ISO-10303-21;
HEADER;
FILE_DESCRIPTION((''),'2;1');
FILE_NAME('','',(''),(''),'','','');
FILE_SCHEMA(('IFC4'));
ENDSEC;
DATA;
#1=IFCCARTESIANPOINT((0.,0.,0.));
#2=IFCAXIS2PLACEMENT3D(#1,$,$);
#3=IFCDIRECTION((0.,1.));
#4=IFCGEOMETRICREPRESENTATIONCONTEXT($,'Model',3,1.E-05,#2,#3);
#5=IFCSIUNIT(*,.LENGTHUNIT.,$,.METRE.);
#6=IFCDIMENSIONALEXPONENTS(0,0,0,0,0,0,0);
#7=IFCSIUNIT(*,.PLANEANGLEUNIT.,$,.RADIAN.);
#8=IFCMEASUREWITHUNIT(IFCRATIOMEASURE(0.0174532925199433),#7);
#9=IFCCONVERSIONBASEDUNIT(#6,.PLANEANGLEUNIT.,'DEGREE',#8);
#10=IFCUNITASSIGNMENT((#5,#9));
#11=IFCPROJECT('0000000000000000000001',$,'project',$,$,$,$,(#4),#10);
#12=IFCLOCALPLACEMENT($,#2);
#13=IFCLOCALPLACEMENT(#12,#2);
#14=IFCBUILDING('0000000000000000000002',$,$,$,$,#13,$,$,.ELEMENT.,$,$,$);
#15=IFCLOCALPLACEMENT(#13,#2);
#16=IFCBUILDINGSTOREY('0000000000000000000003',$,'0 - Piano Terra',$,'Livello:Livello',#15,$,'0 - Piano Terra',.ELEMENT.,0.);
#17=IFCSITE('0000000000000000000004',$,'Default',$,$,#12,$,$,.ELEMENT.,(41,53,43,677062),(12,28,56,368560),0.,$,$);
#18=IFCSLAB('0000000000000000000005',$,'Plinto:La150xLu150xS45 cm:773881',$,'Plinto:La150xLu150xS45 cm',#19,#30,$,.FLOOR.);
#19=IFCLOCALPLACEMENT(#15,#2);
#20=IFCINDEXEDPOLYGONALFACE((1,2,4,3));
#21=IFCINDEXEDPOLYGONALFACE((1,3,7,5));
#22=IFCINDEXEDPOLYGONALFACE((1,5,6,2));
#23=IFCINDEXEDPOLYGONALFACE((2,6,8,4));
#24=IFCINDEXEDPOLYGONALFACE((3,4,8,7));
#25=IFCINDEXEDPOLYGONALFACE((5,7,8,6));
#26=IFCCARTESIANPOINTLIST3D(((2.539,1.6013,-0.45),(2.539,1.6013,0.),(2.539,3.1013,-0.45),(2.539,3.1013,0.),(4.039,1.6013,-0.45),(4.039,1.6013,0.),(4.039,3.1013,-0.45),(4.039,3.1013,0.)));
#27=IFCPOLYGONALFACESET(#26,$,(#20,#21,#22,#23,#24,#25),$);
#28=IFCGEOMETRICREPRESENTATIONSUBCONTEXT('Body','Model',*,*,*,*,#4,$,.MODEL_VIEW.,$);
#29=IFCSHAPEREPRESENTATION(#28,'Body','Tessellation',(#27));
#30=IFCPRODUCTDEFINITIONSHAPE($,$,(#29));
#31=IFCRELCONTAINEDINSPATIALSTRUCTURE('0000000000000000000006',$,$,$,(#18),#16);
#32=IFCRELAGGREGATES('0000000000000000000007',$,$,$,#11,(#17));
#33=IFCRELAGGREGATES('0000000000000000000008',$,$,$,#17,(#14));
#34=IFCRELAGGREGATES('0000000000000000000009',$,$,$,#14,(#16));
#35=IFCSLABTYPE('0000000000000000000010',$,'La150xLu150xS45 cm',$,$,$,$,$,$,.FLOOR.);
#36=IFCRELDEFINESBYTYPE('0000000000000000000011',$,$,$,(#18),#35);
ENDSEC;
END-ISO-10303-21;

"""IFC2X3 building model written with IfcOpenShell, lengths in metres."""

from ifc_helpers import new_model, entity, si_unit, converted_unit, direction, frame, frame_2d, origin, place, context, subcontext, project, spatial, rectangle, extrude, type_object, element, save


model = new_model("IFC2X3")

# Units and contexts
model_context = context("Model", 3, precision=1e-05, world=origin(), true_north=direction((0.0, 1.0)))
body_context = subcontext(model_context, "Body", "Model", "MODEL_VIEW")
ifc_project = project(units=[si_unit("LENGTHUNIT", "METRE"), converted_unit("PLANEANGLEUNIT", "DEGREE", entity("IfcRatioMeasure", 0.0174532925199433), si_unit("PLANEANGLEUNIT", "RADIAN"), dimensions=[0, 0, 0, 0, 0, 0, 0])], contexts=[model_context])

# Site, building, storey
site_placement = place(None, origin())
site = spatial("IfcSite", under=ifc_project, at=site_placement, Name="Default", CompositionType="ELEMENT", RefLatitude=(41, 53, 43, 677062), RefLongitude=(12, 28, 56, 368560), RefElevation=0.0)
building_placement = place(site_placement, origin())
building = spatial("IfcBuilding", under=site, at=building_placement, CompositionType="ELEMENT")
storey_placement = place(building_placement, origin())
storey = spatial("IfcBuildingStorey", under=building, at=storey_placement, Name="0 - Piano Terra", ObjectType="Livello:Livello", LongName="0 - Piano Terra", CompositionType="ELEMENT", Elevation=0.0)

# Slab
slab_type = type_object("IfcSlabType", Name="La150xLu150xS45 cm", PredefinedType="FLOOR")
slab_placement = place(storey_placement, origin())
element("IfcSlab", 1, at=slab_placement, inside=storey, type_object=slab_type, Name="Plinto:La150xLu150xS45 cm:773881", ObjectType="Plinto:La150xLu150xS45 cm", PredefinedType="FLOOR", context=body_context, shape_type="SweptSolid", body=[
    extrude(rectangle(XDim=1.5, YDim=1.5, at=frame_2d((0.0, 0.0), x_axis=(1.0, 0.0))), frame((3.289, 2.3513, -0.45), z_axis=(0.0, 0.0, 1.0), x_axis=(-1.0, 0.0, 0.0)), (0.0, 0.0, 1.0), 0.45),
])

save(model, "model.ifc")
